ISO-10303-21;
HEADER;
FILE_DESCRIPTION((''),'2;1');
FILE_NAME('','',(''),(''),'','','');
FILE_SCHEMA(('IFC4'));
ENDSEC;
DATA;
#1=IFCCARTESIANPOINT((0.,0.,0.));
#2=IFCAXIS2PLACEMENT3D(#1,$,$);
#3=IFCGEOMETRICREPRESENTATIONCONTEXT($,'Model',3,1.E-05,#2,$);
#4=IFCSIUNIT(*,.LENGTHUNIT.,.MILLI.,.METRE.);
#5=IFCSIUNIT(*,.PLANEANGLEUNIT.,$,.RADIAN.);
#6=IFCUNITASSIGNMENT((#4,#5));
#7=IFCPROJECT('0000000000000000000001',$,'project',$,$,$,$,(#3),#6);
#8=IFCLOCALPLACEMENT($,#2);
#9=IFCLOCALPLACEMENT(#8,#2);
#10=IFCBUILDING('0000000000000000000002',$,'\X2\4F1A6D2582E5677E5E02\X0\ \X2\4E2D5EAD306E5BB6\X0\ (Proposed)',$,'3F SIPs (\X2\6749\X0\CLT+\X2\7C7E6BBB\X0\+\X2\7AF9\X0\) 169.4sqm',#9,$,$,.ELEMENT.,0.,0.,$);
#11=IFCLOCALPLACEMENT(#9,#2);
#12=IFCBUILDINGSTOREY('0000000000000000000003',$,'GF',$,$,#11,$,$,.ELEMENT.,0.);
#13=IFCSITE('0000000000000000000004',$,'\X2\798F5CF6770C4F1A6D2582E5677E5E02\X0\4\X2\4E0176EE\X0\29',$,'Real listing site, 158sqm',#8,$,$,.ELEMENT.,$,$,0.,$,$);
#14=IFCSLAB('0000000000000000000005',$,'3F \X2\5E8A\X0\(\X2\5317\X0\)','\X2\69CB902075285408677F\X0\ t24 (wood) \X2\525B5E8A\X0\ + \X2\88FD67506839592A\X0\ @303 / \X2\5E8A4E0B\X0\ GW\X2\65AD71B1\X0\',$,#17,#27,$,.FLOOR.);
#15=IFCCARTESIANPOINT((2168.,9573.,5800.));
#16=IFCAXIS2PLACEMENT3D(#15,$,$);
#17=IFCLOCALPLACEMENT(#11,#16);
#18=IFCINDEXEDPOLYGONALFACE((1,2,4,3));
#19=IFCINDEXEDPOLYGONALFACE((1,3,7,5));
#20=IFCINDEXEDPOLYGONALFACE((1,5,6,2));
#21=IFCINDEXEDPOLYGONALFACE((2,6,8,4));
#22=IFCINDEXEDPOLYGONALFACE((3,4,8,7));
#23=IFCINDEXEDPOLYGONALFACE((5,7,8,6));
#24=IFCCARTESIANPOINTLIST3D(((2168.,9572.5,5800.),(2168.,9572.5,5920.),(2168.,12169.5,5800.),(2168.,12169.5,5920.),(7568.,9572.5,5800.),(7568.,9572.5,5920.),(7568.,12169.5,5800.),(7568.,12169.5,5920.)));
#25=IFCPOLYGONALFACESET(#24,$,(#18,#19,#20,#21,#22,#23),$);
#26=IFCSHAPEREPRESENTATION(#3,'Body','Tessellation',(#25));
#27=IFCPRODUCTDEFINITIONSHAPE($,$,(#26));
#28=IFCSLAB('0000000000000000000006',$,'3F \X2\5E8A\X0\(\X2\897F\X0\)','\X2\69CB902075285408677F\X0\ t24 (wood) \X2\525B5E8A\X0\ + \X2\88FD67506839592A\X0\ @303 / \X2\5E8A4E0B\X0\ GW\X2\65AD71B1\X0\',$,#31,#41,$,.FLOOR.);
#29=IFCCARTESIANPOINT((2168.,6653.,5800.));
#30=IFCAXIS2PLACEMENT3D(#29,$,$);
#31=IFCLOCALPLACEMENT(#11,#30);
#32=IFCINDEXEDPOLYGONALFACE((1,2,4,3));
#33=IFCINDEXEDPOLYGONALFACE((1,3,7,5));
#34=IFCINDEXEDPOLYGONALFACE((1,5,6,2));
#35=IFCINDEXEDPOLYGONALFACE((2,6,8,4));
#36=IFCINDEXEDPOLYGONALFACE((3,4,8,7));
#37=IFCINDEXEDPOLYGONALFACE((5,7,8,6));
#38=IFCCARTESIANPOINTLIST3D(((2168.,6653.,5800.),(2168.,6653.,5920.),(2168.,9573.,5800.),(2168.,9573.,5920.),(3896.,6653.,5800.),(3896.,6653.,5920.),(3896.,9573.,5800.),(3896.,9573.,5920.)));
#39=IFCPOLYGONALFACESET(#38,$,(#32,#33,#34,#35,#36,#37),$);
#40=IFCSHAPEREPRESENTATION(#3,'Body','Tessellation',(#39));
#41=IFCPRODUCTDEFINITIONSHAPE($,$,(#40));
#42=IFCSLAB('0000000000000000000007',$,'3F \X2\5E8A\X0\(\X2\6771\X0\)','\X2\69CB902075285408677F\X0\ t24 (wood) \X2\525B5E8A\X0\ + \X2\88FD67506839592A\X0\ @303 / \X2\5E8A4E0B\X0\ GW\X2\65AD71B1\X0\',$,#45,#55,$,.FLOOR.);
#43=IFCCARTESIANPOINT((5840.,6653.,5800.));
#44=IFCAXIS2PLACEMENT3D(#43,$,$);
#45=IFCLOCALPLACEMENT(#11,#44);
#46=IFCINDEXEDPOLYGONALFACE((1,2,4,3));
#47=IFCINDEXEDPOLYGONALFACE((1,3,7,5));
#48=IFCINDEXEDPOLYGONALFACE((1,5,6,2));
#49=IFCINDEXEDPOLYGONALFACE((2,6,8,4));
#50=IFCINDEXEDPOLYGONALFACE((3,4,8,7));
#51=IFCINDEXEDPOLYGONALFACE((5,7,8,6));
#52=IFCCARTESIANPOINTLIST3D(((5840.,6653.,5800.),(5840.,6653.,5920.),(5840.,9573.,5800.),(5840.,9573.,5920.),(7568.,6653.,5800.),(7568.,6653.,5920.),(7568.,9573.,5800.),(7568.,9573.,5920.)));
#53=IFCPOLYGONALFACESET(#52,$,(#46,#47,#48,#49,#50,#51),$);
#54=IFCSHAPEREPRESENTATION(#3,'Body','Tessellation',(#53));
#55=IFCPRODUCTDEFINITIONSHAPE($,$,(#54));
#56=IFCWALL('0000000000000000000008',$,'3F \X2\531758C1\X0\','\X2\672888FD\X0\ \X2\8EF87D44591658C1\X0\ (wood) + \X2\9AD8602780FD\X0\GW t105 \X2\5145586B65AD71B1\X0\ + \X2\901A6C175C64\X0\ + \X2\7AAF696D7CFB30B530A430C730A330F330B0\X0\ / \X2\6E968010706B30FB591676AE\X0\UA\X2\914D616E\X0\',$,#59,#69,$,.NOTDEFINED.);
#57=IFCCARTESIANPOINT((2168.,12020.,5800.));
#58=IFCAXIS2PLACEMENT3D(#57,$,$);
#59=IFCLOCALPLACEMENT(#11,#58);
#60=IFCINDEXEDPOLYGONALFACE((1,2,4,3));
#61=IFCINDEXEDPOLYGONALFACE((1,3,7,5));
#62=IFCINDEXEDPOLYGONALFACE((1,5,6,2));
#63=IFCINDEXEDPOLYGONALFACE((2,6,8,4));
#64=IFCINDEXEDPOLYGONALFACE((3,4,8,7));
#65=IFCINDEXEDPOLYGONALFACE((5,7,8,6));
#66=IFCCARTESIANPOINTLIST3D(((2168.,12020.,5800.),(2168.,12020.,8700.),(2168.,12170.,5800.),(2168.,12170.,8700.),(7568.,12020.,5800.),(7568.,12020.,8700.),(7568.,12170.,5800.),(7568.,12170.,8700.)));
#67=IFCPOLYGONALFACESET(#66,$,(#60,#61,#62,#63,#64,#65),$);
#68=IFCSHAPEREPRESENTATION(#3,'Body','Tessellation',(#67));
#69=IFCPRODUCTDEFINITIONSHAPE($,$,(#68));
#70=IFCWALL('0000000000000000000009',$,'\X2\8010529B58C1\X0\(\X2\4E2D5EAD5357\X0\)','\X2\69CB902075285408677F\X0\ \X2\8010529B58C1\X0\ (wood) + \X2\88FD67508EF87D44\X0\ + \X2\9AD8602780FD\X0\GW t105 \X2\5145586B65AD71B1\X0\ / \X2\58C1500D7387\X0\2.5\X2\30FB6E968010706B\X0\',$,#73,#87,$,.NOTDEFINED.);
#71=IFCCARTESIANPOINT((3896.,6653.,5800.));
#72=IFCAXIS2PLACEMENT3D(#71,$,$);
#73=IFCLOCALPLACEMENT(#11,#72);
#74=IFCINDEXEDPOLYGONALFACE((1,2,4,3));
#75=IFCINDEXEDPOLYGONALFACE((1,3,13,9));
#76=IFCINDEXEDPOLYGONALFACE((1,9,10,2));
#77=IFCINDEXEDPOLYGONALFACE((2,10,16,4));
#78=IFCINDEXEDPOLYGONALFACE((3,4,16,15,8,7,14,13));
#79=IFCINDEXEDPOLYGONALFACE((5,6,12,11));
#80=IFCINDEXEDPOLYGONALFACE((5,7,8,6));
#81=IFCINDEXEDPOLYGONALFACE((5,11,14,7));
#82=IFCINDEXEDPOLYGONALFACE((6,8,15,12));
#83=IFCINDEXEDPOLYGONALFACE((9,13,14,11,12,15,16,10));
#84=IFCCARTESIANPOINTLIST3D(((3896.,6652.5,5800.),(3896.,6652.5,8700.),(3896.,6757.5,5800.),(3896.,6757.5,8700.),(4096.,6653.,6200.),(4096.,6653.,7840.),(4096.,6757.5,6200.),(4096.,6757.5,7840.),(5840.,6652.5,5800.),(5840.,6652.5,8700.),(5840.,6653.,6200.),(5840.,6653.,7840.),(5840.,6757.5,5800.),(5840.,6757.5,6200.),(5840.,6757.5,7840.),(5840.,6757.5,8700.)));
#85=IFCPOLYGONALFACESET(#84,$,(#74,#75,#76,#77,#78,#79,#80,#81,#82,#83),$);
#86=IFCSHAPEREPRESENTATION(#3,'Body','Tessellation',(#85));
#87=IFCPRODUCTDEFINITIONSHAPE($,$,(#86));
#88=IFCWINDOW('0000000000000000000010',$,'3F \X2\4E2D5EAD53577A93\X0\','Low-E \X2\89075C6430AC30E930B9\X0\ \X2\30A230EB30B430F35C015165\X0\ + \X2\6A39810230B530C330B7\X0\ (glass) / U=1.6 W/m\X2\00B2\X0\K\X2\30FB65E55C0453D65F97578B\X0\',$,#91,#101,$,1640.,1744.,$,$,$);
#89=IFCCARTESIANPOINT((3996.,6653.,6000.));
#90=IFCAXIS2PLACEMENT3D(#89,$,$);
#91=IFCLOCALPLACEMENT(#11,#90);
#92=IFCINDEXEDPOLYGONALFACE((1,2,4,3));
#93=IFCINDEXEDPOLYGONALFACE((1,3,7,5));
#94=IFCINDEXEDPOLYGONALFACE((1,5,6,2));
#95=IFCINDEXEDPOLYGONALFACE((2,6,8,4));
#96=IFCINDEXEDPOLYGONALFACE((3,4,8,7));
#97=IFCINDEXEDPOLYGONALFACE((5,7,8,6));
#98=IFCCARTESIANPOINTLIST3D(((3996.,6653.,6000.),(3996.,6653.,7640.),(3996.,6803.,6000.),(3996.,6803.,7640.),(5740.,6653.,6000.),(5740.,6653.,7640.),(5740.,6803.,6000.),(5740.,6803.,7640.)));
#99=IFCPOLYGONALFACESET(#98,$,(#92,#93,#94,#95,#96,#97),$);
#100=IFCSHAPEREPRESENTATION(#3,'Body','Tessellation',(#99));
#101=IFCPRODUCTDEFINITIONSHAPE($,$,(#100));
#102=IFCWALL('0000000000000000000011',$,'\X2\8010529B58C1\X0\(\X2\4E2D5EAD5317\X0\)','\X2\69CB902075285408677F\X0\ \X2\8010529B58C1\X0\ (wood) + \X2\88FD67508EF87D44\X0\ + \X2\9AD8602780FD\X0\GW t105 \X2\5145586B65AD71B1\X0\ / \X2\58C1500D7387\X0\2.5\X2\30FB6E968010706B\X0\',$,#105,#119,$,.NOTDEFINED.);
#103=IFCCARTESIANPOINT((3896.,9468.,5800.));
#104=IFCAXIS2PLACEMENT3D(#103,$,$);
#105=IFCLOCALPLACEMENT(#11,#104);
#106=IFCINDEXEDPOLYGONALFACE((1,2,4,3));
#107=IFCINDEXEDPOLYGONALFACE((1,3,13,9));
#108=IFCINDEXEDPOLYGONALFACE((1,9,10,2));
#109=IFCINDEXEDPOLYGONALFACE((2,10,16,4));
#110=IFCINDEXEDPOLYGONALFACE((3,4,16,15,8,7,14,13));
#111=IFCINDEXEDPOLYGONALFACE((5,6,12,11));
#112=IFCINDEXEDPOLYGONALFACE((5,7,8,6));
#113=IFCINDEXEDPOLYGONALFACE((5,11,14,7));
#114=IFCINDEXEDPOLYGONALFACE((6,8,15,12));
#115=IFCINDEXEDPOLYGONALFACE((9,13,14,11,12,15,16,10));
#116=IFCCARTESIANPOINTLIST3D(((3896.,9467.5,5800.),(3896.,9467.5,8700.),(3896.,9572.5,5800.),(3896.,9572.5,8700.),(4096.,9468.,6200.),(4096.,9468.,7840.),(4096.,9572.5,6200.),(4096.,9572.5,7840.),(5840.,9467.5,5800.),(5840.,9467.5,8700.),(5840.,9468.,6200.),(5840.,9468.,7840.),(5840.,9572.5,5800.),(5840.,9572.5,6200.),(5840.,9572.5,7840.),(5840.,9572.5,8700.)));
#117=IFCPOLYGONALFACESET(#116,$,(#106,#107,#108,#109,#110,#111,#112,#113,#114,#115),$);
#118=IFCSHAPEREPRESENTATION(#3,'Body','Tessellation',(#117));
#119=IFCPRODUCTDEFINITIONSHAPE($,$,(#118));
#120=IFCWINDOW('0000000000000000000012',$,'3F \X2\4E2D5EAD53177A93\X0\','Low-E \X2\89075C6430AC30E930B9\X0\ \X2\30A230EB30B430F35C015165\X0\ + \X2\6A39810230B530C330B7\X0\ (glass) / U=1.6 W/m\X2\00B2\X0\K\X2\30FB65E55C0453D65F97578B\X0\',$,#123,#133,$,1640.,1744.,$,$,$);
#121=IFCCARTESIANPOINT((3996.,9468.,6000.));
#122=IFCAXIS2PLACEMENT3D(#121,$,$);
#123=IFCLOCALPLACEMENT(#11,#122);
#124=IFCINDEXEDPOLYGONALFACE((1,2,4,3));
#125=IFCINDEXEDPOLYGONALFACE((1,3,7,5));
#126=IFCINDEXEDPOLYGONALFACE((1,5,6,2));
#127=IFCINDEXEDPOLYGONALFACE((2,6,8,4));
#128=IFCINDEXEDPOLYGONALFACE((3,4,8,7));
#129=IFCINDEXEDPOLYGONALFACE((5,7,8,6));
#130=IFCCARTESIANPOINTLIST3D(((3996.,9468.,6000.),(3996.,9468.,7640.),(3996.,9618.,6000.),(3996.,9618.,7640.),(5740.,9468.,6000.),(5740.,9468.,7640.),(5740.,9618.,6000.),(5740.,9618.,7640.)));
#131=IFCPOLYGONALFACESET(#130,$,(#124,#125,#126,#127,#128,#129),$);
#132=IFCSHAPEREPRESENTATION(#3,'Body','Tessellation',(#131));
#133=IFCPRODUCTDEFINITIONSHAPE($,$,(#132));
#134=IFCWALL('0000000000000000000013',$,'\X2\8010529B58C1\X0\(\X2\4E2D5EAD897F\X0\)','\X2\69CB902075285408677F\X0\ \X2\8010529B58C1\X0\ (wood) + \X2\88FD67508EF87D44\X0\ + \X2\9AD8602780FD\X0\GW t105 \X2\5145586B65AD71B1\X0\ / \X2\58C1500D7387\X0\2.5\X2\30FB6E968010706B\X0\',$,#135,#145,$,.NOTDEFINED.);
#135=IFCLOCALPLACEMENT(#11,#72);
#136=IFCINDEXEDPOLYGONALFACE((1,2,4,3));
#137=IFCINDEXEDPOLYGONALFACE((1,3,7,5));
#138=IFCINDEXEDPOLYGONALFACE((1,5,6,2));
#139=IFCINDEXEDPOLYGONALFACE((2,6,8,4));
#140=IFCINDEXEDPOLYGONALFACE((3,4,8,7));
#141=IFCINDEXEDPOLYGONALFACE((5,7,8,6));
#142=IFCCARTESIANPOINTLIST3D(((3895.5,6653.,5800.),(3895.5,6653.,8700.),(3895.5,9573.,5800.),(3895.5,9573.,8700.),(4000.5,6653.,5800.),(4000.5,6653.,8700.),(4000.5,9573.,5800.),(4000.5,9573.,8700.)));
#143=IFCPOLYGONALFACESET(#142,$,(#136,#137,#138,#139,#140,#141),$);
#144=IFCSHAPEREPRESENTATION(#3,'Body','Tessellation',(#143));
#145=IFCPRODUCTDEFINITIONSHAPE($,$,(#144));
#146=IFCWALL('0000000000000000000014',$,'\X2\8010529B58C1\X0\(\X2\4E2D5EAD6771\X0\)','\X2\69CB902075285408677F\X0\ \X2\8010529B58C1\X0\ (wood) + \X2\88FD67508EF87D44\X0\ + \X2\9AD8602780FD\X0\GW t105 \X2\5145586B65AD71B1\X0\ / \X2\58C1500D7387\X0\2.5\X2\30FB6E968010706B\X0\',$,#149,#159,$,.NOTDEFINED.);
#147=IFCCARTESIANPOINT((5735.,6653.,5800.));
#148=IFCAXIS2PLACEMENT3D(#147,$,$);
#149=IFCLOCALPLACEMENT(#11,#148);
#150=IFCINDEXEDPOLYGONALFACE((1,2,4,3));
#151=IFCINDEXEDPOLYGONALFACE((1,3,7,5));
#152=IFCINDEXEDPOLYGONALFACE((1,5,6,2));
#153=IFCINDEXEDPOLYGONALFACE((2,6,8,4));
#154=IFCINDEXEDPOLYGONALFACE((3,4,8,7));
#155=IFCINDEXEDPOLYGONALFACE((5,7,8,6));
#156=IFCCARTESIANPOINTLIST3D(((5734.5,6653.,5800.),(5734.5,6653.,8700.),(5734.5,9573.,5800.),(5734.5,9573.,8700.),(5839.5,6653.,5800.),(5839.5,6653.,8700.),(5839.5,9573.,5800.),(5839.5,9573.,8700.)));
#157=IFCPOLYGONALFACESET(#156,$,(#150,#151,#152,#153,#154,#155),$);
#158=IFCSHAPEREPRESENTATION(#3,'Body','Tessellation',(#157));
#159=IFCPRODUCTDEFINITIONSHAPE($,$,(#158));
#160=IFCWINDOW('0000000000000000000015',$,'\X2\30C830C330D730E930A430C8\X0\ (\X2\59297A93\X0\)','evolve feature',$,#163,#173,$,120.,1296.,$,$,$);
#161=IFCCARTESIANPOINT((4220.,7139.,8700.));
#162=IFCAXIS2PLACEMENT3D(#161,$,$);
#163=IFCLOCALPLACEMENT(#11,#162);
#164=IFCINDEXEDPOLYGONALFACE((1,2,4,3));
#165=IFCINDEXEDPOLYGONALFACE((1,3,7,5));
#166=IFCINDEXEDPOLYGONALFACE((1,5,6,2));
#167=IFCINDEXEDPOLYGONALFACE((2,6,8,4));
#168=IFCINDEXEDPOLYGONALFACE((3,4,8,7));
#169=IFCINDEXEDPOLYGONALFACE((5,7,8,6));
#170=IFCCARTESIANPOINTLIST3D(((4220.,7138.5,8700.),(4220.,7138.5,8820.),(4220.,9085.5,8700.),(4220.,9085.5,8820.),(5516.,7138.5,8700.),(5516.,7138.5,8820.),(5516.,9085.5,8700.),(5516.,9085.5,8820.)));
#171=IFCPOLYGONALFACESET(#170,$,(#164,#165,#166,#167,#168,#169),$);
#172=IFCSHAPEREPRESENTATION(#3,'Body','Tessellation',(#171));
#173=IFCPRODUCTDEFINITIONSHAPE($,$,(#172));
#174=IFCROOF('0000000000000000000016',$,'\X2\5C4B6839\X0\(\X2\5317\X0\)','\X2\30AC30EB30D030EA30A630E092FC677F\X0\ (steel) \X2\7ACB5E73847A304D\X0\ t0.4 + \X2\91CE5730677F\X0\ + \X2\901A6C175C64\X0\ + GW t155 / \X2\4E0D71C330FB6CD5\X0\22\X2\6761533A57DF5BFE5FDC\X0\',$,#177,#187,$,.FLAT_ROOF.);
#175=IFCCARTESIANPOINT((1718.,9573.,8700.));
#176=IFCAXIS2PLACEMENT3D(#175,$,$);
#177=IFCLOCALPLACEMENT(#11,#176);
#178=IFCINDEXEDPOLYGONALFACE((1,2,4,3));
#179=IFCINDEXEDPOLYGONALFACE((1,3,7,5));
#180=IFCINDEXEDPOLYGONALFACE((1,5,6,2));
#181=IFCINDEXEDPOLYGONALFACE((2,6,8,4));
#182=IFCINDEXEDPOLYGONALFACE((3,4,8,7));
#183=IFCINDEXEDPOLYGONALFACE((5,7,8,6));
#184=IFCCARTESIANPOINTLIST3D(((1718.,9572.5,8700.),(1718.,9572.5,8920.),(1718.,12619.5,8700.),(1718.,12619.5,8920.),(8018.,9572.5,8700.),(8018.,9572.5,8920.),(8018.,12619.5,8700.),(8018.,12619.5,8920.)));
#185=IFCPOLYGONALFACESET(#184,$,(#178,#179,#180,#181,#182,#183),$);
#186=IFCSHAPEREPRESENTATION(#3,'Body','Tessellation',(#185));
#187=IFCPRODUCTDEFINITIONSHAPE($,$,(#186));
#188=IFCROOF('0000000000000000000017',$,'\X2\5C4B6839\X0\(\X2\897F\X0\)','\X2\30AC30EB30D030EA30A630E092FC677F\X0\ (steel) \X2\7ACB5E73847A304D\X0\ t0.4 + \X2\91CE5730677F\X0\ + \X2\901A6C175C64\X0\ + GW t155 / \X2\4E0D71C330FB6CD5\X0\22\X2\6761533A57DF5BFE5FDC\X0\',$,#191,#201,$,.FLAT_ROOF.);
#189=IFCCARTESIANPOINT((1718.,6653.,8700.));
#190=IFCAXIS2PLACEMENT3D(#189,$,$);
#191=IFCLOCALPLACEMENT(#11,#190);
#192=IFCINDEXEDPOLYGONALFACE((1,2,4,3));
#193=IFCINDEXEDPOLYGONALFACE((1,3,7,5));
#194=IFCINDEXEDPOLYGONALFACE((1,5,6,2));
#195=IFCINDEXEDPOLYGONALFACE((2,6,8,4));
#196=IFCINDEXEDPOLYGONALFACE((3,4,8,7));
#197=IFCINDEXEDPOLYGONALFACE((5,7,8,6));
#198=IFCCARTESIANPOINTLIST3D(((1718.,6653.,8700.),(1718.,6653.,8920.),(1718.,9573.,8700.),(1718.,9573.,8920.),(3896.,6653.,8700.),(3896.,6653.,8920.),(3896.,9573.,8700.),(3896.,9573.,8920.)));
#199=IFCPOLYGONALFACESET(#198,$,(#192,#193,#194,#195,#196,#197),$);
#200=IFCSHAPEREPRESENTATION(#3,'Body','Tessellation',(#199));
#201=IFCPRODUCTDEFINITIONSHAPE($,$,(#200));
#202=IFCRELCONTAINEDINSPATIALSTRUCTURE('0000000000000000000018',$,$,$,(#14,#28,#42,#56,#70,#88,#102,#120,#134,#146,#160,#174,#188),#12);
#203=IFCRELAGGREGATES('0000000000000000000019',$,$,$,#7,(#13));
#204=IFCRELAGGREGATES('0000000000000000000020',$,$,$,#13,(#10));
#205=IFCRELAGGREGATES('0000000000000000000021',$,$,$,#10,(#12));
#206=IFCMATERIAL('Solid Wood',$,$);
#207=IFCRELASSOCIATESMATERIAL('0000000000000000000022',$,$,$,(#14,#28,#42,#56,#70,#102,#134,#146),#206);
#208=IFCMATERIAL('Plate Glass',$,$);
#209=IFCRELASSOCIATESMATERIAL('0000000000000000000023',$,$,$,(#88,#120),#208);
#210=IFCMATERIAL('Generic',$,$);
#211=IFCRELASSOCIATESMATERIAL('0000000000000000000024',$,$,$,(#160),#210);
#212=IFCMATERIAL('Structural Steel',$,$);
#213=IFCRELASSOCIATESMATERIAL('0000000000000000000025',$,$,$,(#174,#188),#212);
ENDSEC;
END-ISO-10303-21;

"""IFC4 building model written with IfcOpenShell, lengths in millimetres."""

from ifc_helpers import new_model, si_unit, frame, frame_2d, origin, place, context, project, spatial, rectangle, extrude, material, element, fill, save


model = new_model("IFC4")

# Units and contexts
model_context = context("Model", 3, precision=1e-05, world=origin())
ifc_project = project(units=[si_unit("LENGTHUNIT", "METRE", prefix="MILLI"), si_unit("PLANEANGLEUNIT", "RADIAN")], contexts=[model_context])

# Site, building, storey
site_placement = place(None, origin())
site = spatial("IfcSite", under=ifc_project, at=site_placement, Name="福島県会津若松市4丁目29", ObjectType="Real listing site, 158sqm", CompositionType="ELEMENT", RefElevation=0.0)
building_placement = place(site_placement, origin())
building = spatial("IfcBuilding", under=site, at=building_placement, Name="会津若松市 中庭の家 (Proposed)", ObjectType="3F SIPs (杉CLT+籾殻+竹) 169.4sqm", CompositionType="ELEMENT", ElevationOfRefHeight=0.0, ElevationOfTerrain=0.0)
storey_placement = place(building_placement, origin())
storey = spatial("IfcBuildingStorey", under=building, at=storey_placement, Name="GF", CompositionType="ELEMENT", Elevation=0.0)

# Slabs
ifc_material_1 = material(Name="Solid Wood")
slab_1_placement = place(storey_placement, frame((2168.0, 9573.0, 5800.0)))
element("IfcSlab", 1, at=slab_1_placement, inside=storey, material=ifc_material_1, Name="3F 床(北)", Description="構造用合板 t24 (wood) 剛床 + 製材根太 @303 / 床下 GW断熱", PredefinedType="FLOOR", context=model_context, shape_type="SweptSolid", body=[
    extrude(rectangle(XDim=5400.0, YDim=2597.0, at=frame_2d((2700.0, 1298.0))), frame((2168.0, 9573.0, 5800.0)), (0.0, 0.0, 1.0), 120.0),
])
slab_2_placement = place(storey_placement, frame((2168.0, 6653.0, 5800.0)))
element("IfcSlab", 2, at=slab_2_placement, inside=storey, material=ifc_material_1, Name="3F 床(西)", Description="構造用合板 t24 (wood) 剛床 + 製材根太 @303 / 床下 GW断熱", PredefinedType="FLOOR", context=model_context, shape_type="SweptSolid", body=[
    extrude(rectangle(XDim=1728.0, YDim=2920.0, at=frame_2d((864.0, 1460.0))), frame((2168.0, 6653.0, 5800.0)), (0.0, 0.0, 1.0), 120.0),
])
slab_3_placement = place(storey_placement, frame((5840.0, 6653.0, 5800.0)))
element("IfcSlab", 3, at=slab_3_placement, inside=storey, material=ifc_material_1, Name="3F 床(東)", Description="構造用合板 t24 (wood) 剛床 + 製材根太 @303 / 床下 GW断熱", PredefinedType="FLOOR", context=model_context, shape_type="SweptSolid", body=[
    extrude(rectangle(XDim=1728.0, YDim=2920.0, at=frame_2d((864.0, 1460.0))), frame((5840.0, 6653.0, 5800.0)), (0.0, 0.0, 1.0), 120.0),
])

# Wall
wall_1_placement = place(storey_placement, frame((2168.0, 12020.0, 5800.0)))
element("IfcWall", 4, at=wall_1_placement, inside=storey, material=ifc_material_1, Name="3F 北壁", Description="木製 軸組外壁 (wood) + 高性能GW t105 充填断熱 + 通気層 + 窯業系サイディング / 準耐火・外皮UA配慮", PredefinedType="NOTDEFINED", context=model_context, shape_type="SweptSolid", body=[
    extrude(rectangle(XDim=5400.0, YDim=150.0, at=frame_2d((2700.0, 75.0))), frame((2168.0, 12020.0, 5800.0)), (0.0, 0.0, 1.0), 2900.0),
])

# Walls, openings, windows
wall_2_placement = place(storey_placement, frame((3896.0, 6653.0, 5800.0)))
wall_2 = element("IfcWall", 5, at=wall_2_placement, inside=storey, material=ifc_material_1, Name="耐力壁(中庭南)", Description="構造用合板 耐力壁 (wood) + 製材軸組 + 高性能GW t105 充填断熱 / 壁倍率2.5・準耐火", PredefinedType="NOTDEFINED", context=model_context, shape_type="SweptSolid", body=[
    extrude(rectangle(XDim=1944.0, YDim=105.0, at=frame_2d((972.0, 52.0))), frame((3896.0, 6653.0, 5800.0)), (0.0, 0.0, 1.0), 2900.0),
])
opening_1_placement = place(storey_placement, frame((3996.0, 6653.0, 6000.0)))
opening_1 = element("IfcOpeningElement", 6, at=opening_1_placement, cuts=wall_2, PredefinedType="NOTDEFINED", context=model_context, shape_type="SweptSolid", body=[
    extrude(rectangle(XDim=1744.0, YDim=150.0, at=frame_2d((872.0, 75.0))), frame((3996.0, 6653.0, 6000.0)), (0.0, 0.0, 1.0), 1640.0),
])
ifc_material_2 = material(Name="Plate Glass")
window_1_placement = place(storey_placement, frame((3996.0, 6653.0, 6000.0)))
window_1 = element("IfcWindow", 7, at=window_1_placement, inside=storey, material=ifc_material_2, Name="3F 中庭南窓", Description="Low-E 複層ガラス アルゴン封入 + 樹脂サッシ (glass) / U=1.6 W/m²K・日射取得型", OverallHeight=1640.0, OverallWidth=1744.0, context=model_context, shape_type="SweptSolid", body=[
    extrude(rectangle(XDim=1744.0, YDim=150.0, at=frame_2d((872.0, 75.0))), frame((3996.0, 6653.0, 6000.0)), (0.0, 0.0, 1.0), 1640.0),
])
fill(opening_1, window_1)
wall_3_placement = place(storey_placement, frame((3896.0, 9468.0, 5800.0)))
wall_3 = element("IfcWall", 8, at=wall_3_placement, inside=storey, material=ifc_material_1, Name="耐力壁(中庭北)", Description="構造用合板 耐力壁 (wood) + 製材軸組 + 高性能GW t105 充填断熱 / 壁倍率2.5・準耐火", PredefinedType="NOTDEFINED", context=model_context, shape_type="SweptSolid", body=[
    extrude(rectangle(XDim=1944.0, YDim=105.0, at=frame_2d((972.0, 52.0))), frame((3896.0, 9468.0, 5800.0)), (0.0, 0.0, 1.0), 2900.0),
])
opening_2_placement = place(storey_placement, frame((3996.0, 9468.0, 6000.0)))
opening_2 = element("IfcOpeningElement", 9, at=opening_2_placement, cuts=wall_3, PredefinedType="NOTDEFINED", context=model_context, shape_type="SweptSolid", body=[
    extrude(rectangle(XDim=1744.0, YDim=150.0, at=frame_2d((872.0, 75.0))), frame((3996.0, 9468.0, 6000.0)), (0.0, 0.0, 1.0), 1640.0),
])
window_2_placement = place(storey_placement, frame((3996.0, 9468.0, 6000.0)))
window_2 = element("IfcWindow", 10, at=window_2_placement, inside=storey, material=ifc_material_2, Name="3F 中庭北窓", Description="Low-E 複層ガラス アルゴン封入 + 樹脂サッシ (glass) / U=1.6 W/m²K・日射取得型", OverallHeight=1640.0, OverallWidth=1744.0, context=model_context, shape_type="SweptSolid", body=[
    extrude(rectangle(XDim=1744.0, YDim=150.0, at=frame_2d((872.0, 75.0))), frame((3996.0, 9468.0, 6000.0)), (0.0, 0.0, 1.0), 1640.0),
])
fill(opening_2, window_2)

# Walls
wall_4_placement = place(storey_placement, frame((3896.0, 6653.0, 5800.0)))
element("IfcWall", 11, at=wall_4_placement, inside=storey, material=ifc_material_1, Name="耐力壁(中庭西)", Description="構造用合板 耐力壁 (wood) + 製材軸組 + 高性能GW t105 充填断熱 / 壁倍率2.5・準耐火", PredefinedType="NOTDEFINED", context=model_context, shape_type="SweptSolid", body=[
    extrude(rectangle(XDim=105.0, YDim=2920.0, at=frame_2d((52.0, 1460.0))), frame((3896.0, 6653.0, 5800.0)), (0.0, 0.0, 1.0), 2900.0),
])
wall_5_placement = place(storey_placement, frame((5735.0, 6653.0, 5800.0)))
element("IfcWall", 12, at=wall_5_placement, inside=storey, material=ifc_material_1, Name="耐力壁(中庭東)", Description="構造用合板 耐力壁 (wood) + 製材軸組 + 高性能GW t105 充填断熱 / 壁倍率2.5・準耐火", PredefinedType="NOTDEFINED", context=model_context, shape_type="SweptSolid", body=[
    extrude(rectangle(XDim=105.0, YDim=2920.0, at=frame_2d((52.0, 1460.0))), frame((5735.0, 6653.0, 5800.0)), (0.0, 0.0, 1.0), 2900.0),
])

# Window
ifc_material_3 = material(Name="Generic")
window_3_placement = place(storey_placement, frame((4220.0, 7139.0, 8700.0)))
element("IfcWindow", 13, at=window_3_placement, inside=storey, material=ifc_material_3, Name="トップライト (天窓)", Description="evolve feature", OverallHeight=120.0, OverallWidth=1296.0, context=model_context, shape_type="SweptSolid", body=[
    extrude(rectangle(XDim=1296.0, YDim=1947.0, at=frame_2d((648.0, 973.0))), frame((4220.0, 7139.0, 8700.0)), (0.0, 0.0, 1.0), 120.0),
])

# Roofs
ifc_material_4 = material(Name="Structural Steel")
for number, where, name in (
    (14, (1718.0, 9573.0, 8700.0), "屋根(北)"),
):
    element("IfcRoof", number, at=place(storey_placement, frame(where)), inside=storey, material=ifc_material_4, Name=name, Description="ガルバリウム鋼板 (steel) 立平葺き t0.4 + 野地板 + 通気層 + GW t155 / 不燃・法22条区域対応", PredefinedType="FLAT_ROOF", context=model_context, shape_type="SweptSolid", body=[
        extrude(rectangle(XDim=6300.0, YDim=3047.0, at=frame_2d((3150.0, 1523.0))), frame((1718.0, 9573.0, 8700.0)), (0.0, 0.0, 1.0), 220.0),
    ])
roof_1_placement = place(storey_placement, frame((1718.0, 6653.0, 8700.0)))
element("IfcRoof", 15, at=roof_1_placement, inside=storey, material=ifc_material_4, Name="屋根(西)", Description="ガルバリウム鋼板 (steel) 立平葺き t0.4 + 野地板 + 通気層 + GW t155 / 不燃・法22条区域対応", PredefinedType="FLAT_ROOF", context=model_context, shape_type="SweptSolid", body=[
    extrude(rectangle(XDim=2178.0, YDim=2920.0, at=frame_2d((1089.0, 1460.0))), frame((1718.0, 6653.0, 8700.0)), (0.0, 0.0, 1.0), 220.0),
])

save(model, "model.ifc")
